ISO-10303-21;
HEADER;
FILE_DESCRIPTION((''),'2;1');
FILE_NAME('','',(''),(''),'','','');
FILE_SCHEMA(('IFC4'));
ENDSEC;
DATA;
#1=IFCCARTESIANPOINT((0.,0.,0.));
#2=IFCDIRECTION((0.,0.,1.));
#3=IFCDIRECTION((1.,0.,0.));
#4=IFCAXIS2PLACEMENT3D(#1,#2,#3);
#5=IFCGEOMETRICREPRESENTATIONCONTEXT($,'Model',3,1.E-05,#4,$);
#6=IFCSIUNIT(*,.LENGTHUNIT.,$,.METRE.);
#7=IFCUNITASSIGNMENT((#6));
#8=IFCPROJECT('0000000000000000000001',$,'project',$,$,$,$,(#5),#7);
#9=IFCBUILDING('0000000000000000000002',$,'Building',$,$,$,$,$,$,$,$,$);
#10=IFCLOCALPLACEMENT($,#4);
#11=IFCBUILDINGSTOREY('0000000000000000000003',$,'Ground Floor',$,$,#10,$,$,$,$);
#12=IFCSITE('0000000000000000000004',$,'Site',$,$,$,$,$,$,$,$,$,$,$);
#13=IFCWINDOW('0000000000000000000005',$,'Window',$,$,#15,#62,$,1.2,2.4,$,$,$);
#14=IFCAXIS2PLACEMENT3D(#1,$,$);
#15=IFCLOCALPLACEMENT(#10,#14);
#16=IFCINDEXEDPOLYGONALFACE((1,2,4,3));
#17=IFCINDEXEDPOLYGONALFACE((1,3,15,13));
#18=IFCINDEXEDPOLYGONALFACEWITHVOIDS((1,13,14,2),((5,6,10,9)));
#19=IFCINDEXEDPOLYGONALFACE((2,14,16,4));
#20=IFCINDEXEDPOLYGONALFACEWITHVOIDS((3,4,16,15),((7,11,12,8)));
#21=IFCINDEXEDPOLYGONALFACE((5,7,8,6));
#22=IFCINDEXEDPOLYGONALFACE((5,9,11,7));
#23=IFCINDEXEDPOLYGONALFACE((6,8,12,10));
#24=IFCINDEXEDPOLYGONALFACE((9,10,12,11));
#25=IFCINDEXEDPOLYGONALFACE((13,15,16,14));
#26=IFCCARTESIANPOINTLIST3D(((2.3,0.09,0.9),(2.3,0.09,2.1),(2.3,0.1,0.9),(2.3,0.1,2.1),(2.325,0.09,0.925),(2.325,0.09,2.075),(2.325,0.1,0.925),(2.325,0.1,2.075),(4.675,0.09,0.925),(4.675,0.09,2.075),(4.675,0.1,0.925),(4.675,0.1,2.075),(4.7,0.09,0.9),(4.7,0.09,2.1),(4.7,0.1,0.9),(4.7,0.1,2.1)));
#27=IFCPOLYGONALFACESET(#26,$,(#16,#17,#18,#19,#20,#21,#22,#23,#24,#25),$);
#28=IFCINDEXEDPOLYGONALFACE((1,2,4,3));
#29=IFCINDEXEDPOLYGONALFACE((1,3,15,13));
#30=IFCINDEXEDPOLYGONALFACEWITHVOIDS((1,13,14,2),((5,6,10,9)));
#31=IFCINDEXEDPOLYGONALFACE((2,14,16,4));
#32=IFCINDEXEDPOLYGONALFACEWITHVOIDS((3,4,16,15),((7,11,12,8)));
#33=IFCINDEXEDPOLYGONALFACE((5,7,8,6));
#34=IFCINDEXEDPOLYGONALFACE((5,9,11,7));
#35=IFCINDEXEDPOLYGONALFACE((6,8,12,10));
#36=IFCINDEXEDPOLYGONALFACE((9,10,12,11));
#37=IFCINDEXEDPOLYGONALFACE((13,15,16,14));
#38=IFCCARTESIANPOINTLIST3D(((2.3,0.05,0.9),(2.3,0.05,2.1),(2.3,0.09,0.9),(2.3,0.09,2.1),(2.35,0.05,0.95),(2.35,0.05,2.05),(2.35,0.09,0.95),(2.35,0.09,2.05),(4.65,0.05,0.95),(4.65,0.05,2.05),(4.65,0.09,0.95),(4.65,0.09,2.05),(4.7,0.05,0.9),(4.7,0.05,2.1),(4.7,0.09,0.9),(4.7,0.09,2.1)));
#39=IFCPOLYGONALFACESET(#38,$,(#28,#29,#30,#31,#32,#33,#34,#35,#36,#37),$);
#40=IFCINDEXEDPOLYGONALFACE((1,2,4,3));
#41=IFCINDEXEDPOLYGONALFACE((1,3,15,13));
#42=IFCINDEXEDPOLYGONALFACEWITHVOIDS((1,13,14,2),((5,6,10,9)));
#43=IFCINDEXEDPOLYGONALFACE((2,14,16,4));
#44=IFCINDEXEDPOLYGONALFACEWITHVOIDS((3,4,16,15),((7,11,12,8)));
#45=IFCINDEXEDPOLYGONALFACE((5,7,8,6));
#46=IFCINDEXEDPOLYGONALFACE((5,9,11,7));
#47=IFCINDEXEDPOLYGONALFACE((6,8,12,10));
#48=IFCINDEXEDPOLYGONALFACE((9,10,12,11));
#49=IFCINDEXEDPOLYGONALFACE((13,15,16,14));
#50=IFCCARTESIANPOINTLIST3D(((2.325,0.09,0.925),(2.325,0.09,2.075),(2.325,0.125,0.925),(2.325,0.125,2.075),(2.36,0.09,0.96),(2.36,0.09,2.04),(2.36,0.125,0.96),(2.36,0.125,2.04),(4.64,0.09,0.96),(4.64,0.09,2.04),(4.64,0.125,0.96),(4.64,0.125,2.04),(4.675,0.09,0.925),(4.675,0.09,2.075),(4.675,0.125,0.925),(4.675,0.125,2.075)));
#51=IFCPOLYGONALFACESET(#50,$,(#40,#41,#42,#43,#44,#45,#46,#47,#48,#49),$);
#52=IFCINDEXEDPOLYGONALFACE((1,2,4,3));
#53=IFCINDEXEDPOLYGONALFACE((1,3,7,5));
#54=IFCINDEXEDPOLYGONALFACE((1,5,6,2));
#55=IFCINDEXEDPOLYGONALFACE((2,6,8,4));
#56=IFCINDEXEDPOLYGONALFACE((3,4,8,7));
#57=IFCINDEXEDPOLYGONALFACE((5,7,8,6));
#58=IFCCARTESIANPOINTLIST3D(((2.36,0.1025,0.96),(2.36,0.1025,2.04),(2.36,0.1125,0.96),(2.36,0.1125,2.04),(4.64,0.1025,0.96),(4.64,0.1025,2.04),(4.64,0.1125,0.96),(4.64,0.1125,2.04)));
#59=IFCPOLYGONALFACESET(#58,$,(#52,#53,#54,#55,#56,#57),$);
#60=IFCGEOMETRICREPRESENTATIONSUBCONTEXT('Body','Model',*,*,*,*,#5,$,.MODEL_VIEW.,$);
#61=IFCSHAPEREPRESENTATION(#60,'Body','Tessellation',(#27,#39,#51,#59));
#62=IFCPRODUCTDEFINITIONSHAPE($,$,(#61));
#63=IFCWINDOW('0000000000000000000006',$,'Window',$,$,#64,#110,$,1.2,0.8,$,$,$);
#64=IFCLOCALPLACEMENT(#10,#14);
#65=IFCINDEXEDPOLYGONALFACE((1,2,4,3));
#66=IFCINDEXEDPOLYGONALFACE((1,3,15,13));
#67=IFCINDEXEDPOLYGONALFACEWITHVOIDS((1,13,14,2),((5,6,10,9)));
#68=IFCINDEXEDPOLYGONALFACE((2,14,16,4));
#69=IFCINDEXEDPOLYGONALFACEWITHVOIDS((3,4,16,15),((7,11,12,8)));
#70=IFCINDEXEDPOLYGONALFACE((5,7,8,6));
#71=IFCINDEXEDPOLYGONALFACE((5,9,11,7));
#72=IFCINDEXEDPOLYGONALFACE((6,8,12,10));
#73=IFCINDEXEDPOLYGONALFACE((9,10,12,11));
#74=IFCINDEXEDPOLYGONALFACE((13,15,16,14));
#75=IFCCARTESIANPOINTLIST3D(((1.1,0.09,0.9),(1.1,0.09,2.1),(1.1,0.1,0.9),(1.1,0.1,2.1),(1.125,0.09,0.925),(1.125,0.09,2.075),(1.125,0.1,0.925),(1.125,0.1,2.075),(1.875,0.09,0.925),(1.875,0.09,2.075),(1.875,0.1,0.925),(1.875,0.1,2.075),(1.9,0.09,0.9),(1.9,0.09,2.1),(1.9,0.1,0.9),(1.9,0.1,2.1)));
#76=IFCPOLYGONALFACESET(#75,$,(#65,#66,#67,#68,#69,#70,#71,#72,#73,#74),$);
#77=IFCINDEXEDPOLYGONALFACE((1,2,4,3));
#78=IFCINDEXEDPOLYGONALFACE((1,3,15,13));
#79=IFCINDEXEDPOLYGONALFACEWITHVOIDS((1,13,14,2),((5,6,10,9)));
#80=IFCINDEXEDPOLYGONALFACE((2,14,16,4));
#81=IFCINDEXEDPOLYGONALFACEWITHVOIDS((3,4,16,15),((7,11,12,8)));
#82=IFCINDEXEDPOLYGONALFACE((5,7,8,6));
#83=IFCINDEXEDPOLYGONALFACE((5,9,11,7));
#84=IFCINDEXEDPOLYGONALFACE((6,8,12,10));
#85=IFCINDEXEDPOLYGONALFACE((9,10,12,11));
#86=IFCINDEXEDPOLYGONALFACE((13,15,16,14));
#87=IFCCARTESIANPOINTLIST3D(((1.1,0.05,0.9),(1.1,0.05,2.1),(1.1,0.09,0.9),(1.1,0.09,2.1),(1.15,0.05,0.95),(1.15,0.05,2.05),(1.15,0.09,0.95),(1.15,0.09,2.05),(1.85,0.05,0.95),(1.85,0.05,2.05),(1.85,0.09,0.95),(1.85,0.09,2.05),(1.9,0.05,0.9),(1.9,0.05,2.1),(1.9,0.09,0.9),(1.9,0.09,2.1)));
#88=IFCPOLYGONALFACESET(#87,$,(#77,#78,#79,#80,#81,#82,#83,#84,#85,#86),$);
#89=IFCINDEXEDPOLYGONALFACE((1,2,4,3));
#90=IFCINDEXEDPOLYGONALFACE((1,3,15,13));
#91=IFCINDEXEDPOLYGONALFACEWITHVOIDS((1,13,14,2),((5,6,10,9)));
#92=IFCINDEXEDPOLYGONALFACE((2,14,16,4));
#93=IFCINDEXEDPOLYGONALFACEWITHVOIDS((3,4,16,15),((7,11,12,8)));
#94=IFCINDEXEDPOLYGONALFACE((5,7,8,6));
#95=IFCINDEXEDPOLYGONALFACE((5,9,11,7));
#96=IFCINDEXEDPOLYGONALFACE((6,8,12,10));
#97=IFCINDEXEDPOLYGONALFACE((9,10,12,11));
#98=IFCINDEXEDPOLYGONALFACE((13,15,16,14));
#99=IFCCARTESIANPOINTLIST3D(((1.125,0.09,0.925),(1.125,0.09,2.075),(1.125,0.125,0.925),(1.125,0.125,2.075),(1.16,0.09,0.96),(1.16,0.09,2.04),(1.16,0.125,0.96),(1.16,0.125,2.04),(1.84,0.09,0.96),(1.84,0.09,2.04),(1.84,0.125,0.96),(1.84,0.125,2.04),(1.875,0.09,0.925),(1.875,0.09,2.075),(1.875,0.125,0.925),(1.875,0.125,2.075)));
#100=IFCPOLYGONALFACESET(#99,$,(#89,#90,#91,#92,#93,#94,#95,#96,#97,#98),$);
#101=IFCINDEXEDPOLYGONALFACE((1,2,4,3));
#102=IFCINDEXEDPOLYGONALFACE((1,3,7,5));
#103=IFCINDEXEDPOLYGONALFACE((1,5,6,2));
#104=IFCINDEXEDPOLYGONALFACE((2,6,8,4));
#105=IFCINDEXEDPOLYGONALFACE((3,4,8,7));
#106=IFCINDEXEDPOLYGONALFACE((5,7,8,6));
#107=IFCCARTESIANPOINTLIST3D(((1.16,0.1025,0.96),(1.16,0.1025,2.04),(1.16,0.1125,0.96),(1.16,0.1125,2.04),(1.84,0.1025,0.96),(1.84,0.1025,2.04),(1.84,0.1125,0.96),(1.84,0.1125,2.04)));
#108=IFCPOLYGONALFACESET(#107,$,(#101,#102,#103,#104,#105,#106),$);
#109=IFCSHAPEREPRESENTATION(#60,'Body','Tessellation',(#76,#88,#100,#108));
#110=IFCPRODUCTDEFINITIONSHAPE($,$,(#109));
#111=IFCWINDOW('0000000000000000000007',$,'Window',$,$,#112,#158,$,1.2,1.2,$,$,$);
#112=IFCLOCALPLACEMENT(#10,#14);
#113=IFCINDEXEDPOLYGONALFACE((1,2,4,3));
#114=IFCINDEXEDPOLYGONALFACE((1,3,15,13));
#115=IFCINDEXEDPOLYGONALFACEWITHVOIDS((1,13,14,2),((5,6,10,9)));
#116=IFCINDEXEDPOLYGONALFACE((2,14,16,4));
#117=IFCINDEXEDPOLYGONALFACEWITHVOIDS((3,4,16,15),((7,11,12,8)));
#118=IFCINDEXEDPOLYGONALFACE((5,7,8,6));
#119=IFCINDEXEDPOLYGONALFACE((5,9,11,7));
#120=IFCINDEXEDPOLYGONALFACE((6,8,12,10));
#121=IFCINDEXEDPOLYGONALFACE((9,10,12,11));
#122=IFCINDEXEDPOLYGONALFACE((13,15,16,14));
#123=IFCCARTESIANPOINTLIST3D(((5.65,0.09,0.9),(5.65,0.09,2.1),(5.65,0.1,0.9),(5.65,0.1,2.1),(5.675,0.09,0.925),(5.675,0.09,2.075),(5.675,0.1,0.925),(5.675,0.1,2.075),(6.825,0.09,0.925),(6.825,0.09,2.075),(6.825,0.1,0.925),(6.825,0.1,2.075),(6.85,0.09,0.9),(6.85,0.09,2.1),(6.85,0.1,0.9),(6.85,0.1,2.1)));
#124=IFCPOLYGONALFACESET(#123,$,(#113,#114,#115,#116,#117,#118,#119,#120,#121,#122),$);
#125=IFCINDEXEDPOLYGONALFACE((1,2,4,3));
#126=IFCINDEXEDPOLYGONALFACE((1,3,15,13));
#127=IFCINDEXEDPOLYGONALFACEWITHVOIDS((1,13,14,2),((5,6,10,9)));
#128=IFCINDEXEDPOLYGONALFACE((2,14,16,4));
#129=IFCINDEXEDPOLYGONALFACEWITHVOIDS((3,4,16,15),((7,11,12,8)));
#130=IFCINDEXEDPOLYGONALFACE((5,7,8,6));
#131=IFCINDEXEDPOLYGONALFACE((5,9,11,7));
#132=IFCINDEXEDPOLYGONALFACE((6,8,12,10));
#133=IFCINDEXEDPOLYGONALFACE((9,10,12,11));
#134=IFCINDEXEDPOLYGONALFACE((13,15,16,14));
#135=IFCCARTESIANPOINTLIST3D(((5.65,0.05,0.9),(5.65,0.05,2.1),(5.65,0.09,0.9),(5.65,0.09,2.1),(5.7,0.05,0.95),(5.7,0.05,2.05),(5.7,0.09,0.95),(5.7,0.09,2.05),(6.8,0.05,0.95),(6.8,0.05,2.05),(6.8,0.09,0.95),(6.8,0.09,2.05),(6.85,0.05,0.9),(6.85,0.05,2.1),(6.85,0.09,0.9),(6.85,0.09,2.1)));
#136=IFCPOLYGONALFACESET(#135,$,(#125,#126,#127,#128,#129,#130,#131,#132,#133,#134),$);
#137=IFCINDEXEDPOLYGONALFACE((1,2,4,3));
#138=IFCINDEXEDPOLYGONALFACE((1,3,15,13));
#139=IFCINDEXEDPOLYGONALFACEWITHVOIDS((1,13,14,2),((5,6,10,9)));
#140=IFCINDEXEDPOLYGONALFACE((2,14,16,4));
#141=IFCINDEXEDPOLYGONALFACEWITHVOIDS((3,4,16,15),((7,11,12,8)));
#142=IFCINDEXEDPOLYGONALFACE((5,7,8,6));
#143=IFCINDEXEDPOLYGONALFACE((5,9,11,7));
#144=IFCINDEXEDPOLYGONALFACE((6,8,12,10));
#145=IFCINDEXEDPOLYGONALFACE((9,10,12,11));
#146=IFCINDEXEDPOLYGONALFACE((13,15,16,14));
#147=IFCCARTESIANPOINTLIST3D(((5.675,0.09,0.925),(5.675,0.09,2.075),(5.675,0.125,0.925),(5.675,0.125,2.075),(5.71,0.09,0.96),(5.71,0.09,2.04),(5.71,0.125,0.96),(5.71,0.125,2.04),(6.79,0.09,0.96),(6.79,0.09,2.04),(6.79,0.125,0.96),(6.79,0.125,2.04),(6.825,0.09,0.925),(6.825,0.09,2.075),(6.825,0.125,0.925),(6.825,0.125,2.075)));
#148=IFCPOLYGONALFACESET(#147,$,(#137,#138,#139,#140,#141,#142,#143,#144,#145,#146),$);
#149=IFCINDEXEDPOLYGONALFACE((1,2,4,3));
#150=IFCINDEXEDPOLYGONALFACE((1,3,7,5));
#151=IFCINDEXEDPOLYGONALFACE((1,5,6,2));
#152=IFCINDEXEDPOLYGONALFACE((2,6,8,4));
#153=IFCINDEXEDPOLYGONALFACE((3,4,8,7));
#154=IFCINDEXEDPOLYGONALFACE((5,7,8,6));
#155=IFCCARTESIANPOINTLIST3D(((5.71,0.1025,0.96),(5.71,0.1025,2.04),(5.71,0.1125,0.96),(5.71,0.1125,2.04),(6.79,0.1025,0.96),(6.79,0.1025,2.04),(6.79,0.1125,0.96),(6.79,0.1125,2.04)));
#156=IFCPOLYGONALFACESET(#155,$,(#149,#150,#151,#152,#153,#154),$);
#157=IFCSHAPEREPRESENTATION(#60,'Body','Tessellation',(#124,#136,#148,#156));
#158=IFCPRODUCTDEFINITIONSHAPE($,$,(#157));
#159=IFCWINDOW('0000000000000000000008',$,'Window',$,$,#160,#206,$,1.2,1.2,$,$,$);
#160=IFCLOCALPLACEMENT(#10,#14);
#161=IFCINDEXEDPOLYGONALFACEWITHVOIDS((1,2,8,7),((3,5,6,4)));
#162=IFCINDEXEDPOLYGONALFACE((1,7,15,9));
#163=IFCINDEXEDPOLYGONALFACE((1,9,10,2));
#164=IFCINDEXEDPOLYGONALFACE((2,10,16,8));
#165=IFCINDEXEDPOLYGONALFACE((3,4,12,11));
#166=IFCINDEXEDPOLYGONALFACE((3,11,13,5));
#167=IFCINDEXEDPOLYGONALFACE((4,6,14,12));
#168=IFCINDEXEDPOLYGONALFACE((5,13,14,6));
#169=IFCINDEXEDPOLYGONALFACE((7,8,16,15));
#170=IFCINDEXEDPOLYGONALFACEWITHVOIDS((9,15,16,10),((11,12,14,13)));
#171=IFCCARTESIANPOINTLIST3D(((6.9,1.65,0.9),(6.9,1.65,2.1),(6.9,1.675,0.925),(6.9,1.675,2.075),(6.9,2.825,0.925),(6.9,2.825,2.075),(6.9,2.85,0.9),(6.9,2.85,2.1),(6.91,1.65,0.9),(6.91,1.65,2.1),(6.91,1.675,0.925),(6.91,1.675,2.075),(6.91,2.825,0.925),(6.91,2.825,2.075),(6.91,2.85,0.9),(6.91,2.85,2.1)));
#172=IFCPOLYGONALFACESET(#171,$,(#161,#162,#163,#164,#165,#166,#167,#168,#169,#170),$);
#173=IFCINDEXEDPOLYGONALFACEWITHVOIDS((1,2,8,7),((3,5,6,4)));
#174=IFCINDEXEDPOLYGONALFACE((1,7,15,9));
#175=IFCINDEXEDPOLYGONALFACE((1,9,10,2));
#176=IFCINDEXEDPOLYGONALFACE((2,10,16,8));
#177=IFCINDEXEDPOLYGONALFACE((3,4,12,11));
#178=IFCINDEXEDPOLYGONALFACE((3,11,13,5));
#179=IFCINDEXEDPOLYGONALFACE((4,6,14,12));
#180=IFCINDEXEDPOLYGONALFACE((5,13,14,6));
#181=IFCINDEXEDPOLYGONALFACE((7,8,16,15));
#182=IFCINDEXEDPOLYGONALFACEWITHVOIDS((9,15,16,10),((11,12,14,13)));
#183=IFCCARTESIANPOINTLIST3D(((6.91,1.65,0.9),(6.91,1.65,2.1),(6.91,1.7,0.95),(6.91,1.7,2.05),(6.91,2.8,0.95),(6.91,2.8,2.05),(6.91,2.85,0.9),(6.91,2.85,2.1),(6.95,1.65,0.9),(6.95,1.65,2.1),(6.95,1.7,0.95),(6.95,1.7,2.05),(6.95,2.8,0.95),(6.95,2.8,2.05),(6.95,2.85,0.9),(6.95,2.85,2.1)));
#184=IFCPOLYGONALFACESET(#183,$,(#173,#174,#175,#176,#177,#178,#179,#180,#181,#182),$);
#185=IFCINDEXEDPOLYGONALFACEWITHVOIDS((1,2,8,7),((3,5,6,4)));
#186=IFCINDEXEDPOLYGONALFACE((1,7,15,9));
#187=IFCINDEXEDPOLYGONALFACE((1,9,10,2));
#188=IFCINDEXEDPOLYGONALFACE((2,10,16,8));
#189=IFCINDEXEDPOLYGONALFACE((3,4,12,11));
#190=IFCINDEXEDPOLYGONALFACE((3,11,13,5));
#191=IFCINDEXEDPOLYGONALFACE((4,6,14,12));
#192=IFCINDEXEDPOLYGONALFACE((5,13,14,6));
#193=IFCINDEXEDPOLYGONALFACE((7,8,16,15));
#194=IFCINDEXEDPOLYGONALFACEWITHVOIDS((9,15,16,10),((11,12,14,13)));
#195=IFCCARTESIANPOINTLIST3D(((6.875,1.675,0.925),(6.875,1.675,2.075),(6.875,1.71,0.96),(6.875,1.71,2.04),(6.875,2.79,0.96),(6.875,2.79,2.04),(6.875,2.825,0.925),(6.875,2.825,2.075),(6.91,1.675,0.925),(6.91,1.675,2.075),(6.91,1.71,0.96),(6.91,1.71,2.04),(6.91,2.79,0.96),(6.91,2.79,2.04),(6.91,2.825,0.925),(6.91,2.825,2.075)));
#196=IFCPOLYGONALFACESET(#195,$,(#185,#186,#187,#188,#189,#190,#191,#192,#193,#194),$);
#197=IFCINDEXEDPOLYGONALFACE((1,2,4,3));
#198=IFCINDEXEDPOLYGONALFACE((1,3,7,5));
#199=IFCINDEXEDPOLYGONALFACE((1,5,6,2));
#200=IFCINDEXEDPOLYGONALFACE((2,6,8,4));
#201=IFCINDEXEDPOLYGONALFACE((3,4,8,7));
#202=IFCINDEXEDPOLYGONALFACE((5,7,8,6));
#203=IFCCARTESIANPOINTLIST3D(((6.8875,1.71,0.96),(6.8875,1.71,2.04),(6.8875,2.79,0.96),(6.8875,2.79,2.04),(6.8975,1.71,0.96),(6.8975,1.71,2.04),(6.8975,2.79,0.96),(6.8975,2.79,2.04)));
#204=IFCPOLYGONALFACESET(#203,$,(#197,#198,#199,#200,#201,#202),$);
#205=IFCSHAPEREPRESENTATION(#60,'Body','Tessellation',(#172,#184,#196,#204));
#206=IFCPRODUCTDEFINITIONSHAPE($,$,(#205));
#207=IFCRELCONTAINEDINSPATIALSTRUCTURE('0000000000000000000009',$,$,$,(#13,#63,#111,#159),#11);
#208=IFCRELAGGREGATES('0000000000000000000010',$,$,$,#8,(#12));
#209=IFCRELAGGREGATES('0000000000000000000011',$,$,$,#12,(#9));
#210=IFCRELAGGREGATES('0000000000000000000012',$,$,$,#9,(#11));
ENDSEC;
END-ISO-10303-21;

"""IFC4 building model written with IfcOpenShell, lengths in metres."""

from ifc_helpers import new_model, si_unit, frame, origin_with_axes, place, context, subcontext, project, spatial, line, indexed_curve, outline, extrude, element, save


model = new_model("IFC4")

# Units and contexts
model_context = context("Model", 3, precision=1e-05, world=origin_with_axes())
body_context = subcontext(model_context, "Body", "Model", "MODEL_VIEW")
ifc_project = project(units=[si_unit("LENGTHUNIT", "METRE")], contexts=[model_context])

# Site, building, storey
site = spatial("IfcSite", under=ifc_project, Name="Site")
building = spatial("IfcBuilding", under=site, Name="Building")
storey_placement = place(None, origin_with_axes())
storey = spatial("IfcBuildingStorey", under=building, at=storey_placement, Name="Ground Floor")

# Windows
window_1_placement = place(storey_placement, frame((2.3, 0.0, 0.9), z_axis=(0.0, 0.0, 1.0), x_axis=(1.0, 0.0, 0.0)))
element("IfcWindow", 1, at=window_1_placement, inside=storey, Name="Window", OverallHeight=1.2, OverallWidth=2.4, context=body_context, shape_type="SweptSolid", body=[
    extrude(outline(indexed_curve([(0.0, 0.0), (2.4, 0.0), (2.4, 1.2), (0.0, 1.2)], segments=[line(1, 2, 3, 4, 1)]), holes=[indexed_curve([(0.025, 0.025), (2.375, 0.025), (2.375, 1.175), (0.025, 1.175)], segments=[line(1, 2, 3, 4, 1)])]), frame((0.0, 0.09, 0.0), z_axis=(0.0, -1.0, 0.0), x_axis=(1.0, 0.0, 0.0)), (0.0, 0.0, -1.0), 0.01),
    extrude(outline(indexed_curve([(0.0, 0.0), (2.4, 0.0), (2.4, 1.2), (0.0, 1.2)], segments=[line(1, 2, 3, 4, 1)]), holes=[indexed_curve([(0.05, 0.05), (2.35, 0.05), (2.35, 1.15), (0.05, 1.15)], segments=[line(1, 2, 3, 4, 1)])]), frame((0.0, 0.05, 0.0), z_axis=(0.0, -1.0, 0.0), x_axis=(1.0, 0.0, 0.0)), (0.0, 0.0, -1.0), 0.04),
    extrude(outline(indexed_curve([(0.0, 0.0), (2.35, 0.0), (2.35, 1.15), (0.0, 1.15)], segments=[line(1, 2, 3, 4, 1)]), holes=[indexed_curve([(0.035, 0.035), (2.315, 0.035), (2.315, 1.115), (0.035, 1.115)], segments=[line(1, 2, 3, 4, 1)])]), frame((0.025, 0.09, 0.025), z_axis=(0.0, -1.0, 0.0), x_axis=(1.0, 0.0, 0.0)), (0.0, 0.0, -1.0), 0.035),
    extrude(outline(indexed_curve([(0.035, 0.035), (2.315, 0.035), (2.315, 1.115), (0.035, 1.115)], segments=[line(1, 2, 3, 4, 1)])), frame((0.025, 0.1025, 0.025), z_axis=(0.0, -1.0, 0.0), x_axis=(1.0, 0.0, 0.0)), (0.0, 0.0, -1.0), 0.01),
])
window_2_placement = place(storey_placement, frame((1.1, 0.0, 0.9), z_axis=(0.0, 0.0, 1.0), x_axis=(1.0, 0.0, 0.0)))
element("IfcWindow", 2, at=window_2_placement, inside=storey, Name="Window", OverallHeight=1.2, OverallWidth=0.8, context=body_context, shape_type="SweptSolid", body=[
    extrude(outline(indexed_curve([(0.0, 0.0), (0.8, 0.0), (0.8, 1.2), (0.0, 1.2)], segments=[line(1, 2, 3, 4, 1)]), holes=[indexed_curve([(0.025, 0.025), (0.775, 0.025), (0.775, 1.175), (0.025, 1.175)], segments=[line(1, 2, 3, 4, 1)])]), frame((0.0, 0.09, 0.0), z_axis=(0.0, -1.0, 0.0), x_axis=(1.0, 0.0, 0.0)), (0.0, 0.0, -1.0), 0.01),
    extrude(outline(indexed_curve([(0.0, 0.0), (0.8, 0.0), (0.8, 1.2), (0.0, 1.2)], segments=[line(1, 2, 3, 4, 1)]), holes=[indexed_curve([(0.05, 0.05), (0.75, 0.05), (0.75, 1.15), (0.05, 1.15)], segments=[line(1, 2, 3, 4, 1)])]), frame((0.0, 0.05, 0.0), z_axis=(0.0, -1.0, 0.0), x_axis=(1.0, 0.0, 0.0)), (0.0, 0.0, -1.0), 0.04),
    extrude(outline(indexed_curve([(0.0, 0.0), (0.75, 0.0), (0.75, 1.15), (0.0, 1.15)], segments=[line(1, 2, 3, 4, 1)]), holes=[indexed_curve([(0.035, 0.035), (0.715, 0.035), (0.715, 1.115), (0.035, 1.115)], segments=[line(1, 2, 3, 4, 1)])]), frame((0.025, 0.09, 0.025), z_axis=(0.0, -1.0, 0.0), x_axis=(1.0, 0.0, 0.0)), (0.0, 0.0, -1.0), 0.035),
    extrude(outline(indexed_curve([(0.035, 0.035), (0.715, 0.035), (0.715, 1.115), (0.035, 1.115)], segments=[line(1, 2, 3, 4, 1)])), frame((0.025, 0.1025, 0.025), z_axis=(0.0, -1.0, 0.0), x_axis=(1.0, 0.0, 0.0)), (0.0, 0.0, -1.0), 0.01),
])
for number, where, z_axis, x_axis, name in (
    (3, (5.65, 0.0, 0.9), (0.0, 0.0, 1.0), (1.0, 0.0, 0.0), "Window"),
    (4, (7.0, 1.65, 0.9), (0.0, 0.0, 1.0), (0.0, 1.0, 0.0), "Window"),
):
    element("IfcWindow", number, at=place(storey_placement, frame(where, z_axis=z_axis, x_axis=x_axis)), inside=storey, Name=name, OverallHeight=1.2, OverallWidth=1.2, context=body_context, shape_type="SweptSolid", body=[
        extrude(outline(indexed_curve([(0.0, 0.0), (1.2, 0.0), (1.2, 1.2), (0.0, 1.2)], segments=[line(1, 2, 3, 4, 1)]), holes=[indexed_curve([(0.025, 0.025), (1.175, 0.025), (1.175, 1.175), (0.025, 1.175)], segments=[line(1, 2, 3, 4, 1)])]), frame((0.0, 0.09, 0.0), z_axis=(0.0, -1.0, 0.0), x_axis=(1.0, 0.0, 0.0)), (0.0, 0.0, -1.0), 0.01),
        extrude(outline(indexed_curve([(0.0, 0.0), (1.2, 0.0), (1.2, 1.2), (0.0, 1.2)], segments=[line(1, 2, 3, 4, 1)]), holes=[indexed_curve([(0.05, 0.05), (1.15, 0.05), (1.15, 1.15), (0.05, 1.15)], segments=[line(1, 2, 3, 4, 1)])]), frame((0.0, 0.05, 0.0), z_axis=(0.0, -1.0, 0.0), x_axis=(1.0, 0.0, 0.0)), (0.0, 0.0, -1.0), 0.04),
        extrude(outline(indexed_curve([(0.0, 0.0), (1.15, 0.0), (1.15, 1.15), (0.0, 1.15)], segments=[line(1, 2, 3, 4, 1)]), holes=[indexed_curve([(0.035, 0.035), (1.115, 0.035), (1.115, 1.115), (0.035, 1.115)], segments=[line(1, 2, 3, 4, 1)])]), frame((0.025, 0.09, 0.025), z_axis=(0.0, -1.0, 0.0), x_axis=(1.0, 0.0, 0.0)), (0.0, 0.0, -1.0), 0.035),
        extrude(outline(indexed_curve([(0.035, 0.035), (1.115, 0.035), (1.115, 1.115), (0.035, 1.115)], segments=[line(1, 2, 3, 4, 1)])), frame((0.025, 0.1025, 0.025), z_axis=(0.0, -1.0, 0.0), x_axis=(1.0, 0.0, 0.0)), (0.0, 0.0, -1.0), 0.01),
    ])

save(model, "model.ifc")
